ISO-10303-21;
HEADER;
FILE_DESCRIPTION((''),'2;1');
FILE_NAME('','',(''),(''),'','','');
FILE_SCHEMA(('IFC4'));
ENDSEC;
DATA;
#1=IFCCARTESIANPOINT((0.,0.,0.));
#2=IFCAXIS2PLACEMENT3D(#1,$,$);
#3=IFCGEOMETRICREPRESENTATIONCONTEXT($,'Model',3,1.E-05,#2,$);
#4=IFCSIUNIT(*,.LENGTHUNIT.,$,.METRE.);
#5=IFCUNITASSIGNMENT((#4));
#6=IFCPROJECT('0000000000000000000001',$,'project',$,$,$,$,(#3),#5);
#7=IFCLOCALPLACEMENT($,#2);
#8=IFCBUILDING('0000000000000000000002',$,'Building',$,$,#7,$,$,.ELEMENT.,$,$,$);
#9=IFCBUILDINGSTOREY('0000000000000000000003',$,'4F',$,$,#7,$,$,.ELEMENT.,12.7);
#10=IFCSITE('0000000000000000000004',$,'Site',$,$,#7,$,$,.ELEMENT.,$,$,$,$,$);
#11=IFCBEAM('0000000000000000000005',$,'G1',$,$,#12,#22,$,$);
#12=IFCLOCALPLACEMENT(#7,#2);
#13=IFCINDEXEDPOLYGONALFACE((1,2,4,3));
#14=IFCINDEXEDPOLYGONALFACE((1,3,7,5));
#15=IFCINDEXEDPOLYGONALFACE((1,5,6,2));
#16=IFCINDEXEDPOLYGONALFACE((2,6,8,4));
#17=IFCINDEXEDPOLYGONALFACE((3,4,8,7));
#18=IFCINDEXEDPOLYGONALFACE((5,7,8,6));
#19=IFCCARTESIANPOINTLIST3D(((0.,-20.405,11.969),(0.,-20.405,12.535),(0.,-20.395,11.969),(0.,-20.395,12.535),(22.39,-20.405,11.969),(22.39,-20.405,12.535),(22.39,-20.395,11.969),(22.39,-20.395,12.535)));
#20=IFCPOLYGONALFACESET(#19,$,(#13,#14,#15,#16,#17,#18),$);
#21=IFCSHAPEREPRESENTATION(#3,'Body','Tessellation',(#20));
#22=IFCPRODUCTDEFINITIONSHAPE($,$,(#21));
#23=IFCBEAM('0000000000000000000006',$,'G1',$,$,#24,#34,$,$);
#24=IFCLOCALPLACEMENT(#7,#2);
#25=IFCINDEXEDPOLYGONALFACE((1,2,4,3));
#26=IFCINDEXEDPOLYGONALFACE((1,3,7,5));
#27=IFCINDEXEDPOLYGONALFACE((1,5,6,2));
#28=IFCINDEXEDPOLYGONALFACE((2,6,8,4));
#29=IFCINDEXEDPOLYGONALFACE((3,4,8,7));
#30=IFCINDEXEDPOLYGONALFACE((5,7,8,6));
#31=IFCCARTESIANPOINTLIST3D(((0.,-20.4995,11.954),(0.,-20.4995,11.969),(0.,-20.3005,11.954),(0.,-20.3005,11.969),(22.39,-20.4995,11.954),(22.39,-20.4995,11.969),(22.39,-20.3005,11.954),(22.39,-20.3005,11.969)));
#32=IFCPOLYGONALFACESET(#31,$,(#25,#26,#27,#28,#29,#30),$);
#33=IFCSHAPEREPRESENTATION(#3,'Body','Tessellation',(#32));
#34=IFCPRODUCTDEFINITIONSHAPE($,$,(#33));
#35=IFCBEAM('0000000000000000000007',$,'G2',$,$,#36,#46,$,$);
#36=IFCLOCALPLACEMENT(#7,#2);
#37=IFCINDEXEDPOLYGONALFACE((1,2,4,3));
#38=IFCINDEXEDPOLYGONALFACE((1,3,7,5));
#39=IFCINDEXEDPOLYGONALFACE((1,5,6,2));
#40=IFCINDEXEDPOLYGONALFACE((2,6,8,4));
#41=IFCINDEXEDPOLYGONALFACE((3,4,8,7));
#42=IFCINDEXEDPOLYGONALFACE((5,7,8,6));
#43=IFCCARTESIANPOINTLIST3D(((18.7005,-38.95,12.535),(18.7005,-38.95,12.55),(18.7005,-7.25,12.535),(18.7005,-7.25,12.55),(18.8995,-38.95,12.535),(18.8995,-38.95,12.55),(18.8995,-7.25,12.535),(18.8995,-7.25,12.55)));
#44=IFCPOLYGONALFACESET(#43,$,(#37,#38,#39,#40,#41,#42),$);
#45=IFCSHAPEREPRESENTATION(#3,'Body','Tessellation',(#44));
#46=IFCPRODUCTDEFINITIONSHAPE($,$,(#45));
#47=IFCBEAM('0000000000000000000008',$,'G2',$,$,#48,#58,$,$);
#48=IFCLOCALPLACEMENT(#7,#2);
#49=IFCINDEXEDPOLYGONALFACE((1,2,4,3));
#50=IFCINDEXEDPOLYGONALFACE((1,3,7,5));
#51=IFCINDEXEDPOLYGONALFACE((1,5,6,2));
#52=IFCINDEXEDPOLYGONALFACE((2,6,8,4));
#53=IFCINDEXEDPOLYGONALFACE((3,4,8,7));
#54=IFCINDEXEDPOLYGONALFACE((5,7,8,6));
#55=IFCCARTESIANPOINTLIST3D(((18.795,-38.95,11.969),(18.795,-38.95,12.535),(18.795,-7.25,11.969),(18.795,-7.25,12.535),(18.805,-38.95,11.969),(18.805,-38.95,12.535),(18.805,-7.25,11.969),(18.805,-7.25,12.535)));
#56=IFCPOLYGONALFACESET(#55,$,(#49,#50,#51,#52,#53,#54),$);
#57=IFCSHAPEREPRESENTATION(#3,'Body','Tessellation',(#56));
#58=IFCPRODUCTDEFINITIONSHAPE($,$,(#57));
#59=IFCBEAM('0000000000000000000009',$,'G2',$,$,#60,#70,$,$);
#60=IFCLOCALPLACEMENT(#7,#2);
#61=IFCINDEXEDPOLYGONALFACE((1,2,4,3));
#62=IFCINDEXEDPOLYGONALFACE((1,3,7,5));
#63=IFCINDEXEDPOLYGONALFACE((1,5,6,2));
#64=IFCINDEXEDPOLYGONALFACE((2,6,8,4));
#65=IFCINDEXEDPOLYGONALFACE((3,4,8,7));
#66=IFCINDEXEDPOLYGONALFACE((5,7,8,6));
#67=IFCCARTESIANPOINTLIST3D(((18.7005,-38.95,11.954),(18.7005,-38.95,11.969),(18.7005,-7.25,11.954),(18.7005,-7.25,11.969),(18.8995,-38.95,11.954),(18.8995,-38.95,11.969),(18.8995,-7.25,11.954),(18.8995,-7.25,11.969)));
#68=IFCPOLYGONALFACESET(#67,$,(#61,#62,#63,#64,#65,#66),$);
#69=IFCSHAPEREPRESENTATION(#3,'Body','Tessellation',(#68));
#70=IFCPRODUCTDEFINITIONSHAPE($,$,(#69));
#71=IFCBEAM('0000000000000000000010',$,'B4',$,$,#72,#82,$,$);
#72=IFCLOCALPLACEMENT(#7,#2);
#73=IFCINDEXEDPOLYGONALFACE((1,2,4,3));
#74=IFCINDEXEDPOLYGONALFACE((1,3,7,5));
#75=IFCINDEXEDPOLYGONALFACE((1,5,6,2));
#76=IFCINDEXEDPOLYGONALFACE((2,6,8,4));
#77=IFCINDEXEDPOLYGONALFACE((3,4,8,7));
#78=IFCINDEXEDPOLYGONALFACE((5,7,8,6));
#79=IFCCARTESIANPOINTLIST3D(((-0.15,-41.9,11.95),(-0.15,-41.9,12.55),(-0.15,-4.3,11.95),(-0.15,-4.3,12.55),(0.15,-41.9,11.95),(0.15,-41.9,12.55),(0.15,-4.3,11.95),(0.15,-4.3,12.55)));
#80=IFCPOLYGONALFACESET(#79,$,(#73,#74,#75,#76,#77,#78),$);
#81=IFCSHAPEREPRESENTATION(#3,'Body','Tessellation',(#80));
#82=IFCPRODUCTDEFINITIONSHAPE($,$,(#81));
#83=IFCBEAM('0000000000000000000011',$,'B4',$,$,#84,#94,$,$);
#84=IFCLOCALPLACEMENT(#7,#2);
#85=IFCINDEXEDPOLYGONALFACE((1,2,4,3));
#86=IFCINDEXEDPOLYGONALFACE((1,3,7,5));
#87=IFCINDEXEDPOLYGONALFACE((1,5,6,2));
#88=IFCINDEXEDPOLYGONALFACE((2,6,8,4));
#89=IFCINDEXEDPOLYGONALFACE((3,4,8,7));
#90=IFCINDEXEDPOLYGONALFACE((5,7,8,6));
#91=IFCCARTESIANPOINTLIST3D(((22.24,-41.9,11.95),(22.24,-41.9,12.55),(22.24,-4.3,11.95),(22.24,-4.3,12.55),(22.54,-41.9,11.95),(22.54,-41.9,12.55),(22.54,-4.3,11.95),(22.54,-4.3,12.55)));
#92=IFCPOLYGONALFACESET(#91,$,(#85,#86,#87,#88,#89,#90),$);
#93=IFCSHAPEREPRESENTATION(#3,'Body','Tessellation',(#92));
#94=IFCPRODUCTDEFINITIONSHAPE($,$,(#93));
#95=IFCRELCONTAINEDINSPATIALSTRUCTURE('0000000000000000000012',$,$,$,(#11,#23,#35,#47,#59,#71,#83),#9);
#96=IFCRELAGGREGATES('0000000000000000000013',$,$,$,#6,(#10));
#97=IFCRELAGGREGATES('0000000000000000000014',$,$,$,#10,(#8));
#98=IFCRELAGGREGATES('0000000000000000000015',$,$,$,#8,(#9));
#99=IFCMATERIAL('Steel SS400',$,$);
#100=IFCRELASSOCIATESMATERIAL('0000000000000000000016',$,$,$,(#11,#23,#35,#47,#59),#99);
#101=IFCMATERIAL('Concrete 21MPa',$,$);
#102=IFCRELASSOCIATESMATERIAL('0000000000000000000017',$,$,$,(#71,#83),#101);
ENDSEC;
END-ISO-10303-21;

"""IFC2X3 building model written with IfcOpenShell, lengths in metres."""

from ifc_helpers import new_model, si_unit, frame, origin, origin_2d, place, context, project, spatial, rectangle, extrude, material, element, save


model = new_model("IFC2X3")

# Units and contexts
model_context = context("Model", 3, precision=1e-05, world=origin())
ifc_project = project(units=[si_unit("LENGTHUNIT", "METRE")], contexts=[model_context])

# Site, building, storey
placement = place(None, origin())
site = spatial("IfcSite", under=ifc_project, at=placement, Name="Site", CompositionType="ELEMENT")
building = spatial("IfcBuilding", under=site, at=placement, Name="Building", CompositionType="ELEMENT")
storey = spatial("IfcBuildingStorey", under=building, at=placement, Name="4F", CompositionType="ELEMENT", Elevation=12.7)

# Shared definitions
ifc_material_1 = material(Name="Concrete 21MPa")
ifc_material_2 = material(Name="Steel SS400")

# Beams
beam_1_placement = place(None, frame((11.195, -20.4, 11.969)))
element("IfcBeam", 1, at=beam_1_placement, inside=storey, material=ifc_material_2, Name="G1", context=model_context, shape_type="SweptSolid", body=[
    extrude(rectangle(XDim=22.39, YDim=0.01, at=origin_2d()), origin(), (0.0, 0.0, 1.0), 0.566),
])
beam_2_placement = place(None, frame((11.195, -20.4, 11.954)))
element("IfcBeam", 2, at=beam_2_placement, inside=storey, material=ifc_material_2, Name="G1", context=model_context, shape_type="SweptSolid", body=[
    extrude(rectangle(XDim=22.39, YDim=0.199, at=origin_2d()), origin(), (0.0, 0.0, 1.0), 0.015),
])
beam_3_placement = place(None, frame((18.8, -23.1, 12.535)))
element("IfcBeam", 3, at=beam_3_placement, inside=storey, material=ifc_material_2, Name="G2", context=model_context, shape_type="SweptSolid", body=[
    extrude(rectangle(XDim=0.199, YDim=31.7, at=origin_2d()), origin(), (0.0, 0.0, 1.0), 0.015),
])
beam_4_placement = place(None, frame((18.8, -23.1, 11.969)))
element("IfcBeam", 4, at=beam_4_placement, inside=storey, material=ifc_material_2, Name="G2", context=model_context, shape_type="SweptSolid", body=[
    extrude(rectangle(XDim=0.01, YDim=31.7, at=origin_2d()), origin(), (0.0, 0.0, 1.0), 0.566),
])
beam_5_placement = place(None, frame((18.8, -23.1, 11.954)))
element("IfcBeam", 5, at=beam_5_placement, inside=storey, material=ifc_material_2, Name="G2", context=model_context, shape_type="SweptSolid", body=[
    extrude(rectangle(XDim=0.199, YDim=31.7, at=origin_2d()), origin(), (0.0, 0.0, 1.0), 0.015),
])
for number, where, name in (
    (6, (0.0, -23.1, 11.95), "B4"),
    (7, (22.39, -23.1, 11.95), "B4"),
):
    element("IfcBeam", number, at=place(None, frame(where)), inside=storey, material=ifc_material_1, Name=name, context=model_context, shape_type="SweptSolid", body=[
        extrude(rectangle(XDim=0.3, YDim=37.6, at=origin_2d()), origin(), (0.0, 0.0, 1.0), 0.6),
    ])

save(model, "model.ifc")
